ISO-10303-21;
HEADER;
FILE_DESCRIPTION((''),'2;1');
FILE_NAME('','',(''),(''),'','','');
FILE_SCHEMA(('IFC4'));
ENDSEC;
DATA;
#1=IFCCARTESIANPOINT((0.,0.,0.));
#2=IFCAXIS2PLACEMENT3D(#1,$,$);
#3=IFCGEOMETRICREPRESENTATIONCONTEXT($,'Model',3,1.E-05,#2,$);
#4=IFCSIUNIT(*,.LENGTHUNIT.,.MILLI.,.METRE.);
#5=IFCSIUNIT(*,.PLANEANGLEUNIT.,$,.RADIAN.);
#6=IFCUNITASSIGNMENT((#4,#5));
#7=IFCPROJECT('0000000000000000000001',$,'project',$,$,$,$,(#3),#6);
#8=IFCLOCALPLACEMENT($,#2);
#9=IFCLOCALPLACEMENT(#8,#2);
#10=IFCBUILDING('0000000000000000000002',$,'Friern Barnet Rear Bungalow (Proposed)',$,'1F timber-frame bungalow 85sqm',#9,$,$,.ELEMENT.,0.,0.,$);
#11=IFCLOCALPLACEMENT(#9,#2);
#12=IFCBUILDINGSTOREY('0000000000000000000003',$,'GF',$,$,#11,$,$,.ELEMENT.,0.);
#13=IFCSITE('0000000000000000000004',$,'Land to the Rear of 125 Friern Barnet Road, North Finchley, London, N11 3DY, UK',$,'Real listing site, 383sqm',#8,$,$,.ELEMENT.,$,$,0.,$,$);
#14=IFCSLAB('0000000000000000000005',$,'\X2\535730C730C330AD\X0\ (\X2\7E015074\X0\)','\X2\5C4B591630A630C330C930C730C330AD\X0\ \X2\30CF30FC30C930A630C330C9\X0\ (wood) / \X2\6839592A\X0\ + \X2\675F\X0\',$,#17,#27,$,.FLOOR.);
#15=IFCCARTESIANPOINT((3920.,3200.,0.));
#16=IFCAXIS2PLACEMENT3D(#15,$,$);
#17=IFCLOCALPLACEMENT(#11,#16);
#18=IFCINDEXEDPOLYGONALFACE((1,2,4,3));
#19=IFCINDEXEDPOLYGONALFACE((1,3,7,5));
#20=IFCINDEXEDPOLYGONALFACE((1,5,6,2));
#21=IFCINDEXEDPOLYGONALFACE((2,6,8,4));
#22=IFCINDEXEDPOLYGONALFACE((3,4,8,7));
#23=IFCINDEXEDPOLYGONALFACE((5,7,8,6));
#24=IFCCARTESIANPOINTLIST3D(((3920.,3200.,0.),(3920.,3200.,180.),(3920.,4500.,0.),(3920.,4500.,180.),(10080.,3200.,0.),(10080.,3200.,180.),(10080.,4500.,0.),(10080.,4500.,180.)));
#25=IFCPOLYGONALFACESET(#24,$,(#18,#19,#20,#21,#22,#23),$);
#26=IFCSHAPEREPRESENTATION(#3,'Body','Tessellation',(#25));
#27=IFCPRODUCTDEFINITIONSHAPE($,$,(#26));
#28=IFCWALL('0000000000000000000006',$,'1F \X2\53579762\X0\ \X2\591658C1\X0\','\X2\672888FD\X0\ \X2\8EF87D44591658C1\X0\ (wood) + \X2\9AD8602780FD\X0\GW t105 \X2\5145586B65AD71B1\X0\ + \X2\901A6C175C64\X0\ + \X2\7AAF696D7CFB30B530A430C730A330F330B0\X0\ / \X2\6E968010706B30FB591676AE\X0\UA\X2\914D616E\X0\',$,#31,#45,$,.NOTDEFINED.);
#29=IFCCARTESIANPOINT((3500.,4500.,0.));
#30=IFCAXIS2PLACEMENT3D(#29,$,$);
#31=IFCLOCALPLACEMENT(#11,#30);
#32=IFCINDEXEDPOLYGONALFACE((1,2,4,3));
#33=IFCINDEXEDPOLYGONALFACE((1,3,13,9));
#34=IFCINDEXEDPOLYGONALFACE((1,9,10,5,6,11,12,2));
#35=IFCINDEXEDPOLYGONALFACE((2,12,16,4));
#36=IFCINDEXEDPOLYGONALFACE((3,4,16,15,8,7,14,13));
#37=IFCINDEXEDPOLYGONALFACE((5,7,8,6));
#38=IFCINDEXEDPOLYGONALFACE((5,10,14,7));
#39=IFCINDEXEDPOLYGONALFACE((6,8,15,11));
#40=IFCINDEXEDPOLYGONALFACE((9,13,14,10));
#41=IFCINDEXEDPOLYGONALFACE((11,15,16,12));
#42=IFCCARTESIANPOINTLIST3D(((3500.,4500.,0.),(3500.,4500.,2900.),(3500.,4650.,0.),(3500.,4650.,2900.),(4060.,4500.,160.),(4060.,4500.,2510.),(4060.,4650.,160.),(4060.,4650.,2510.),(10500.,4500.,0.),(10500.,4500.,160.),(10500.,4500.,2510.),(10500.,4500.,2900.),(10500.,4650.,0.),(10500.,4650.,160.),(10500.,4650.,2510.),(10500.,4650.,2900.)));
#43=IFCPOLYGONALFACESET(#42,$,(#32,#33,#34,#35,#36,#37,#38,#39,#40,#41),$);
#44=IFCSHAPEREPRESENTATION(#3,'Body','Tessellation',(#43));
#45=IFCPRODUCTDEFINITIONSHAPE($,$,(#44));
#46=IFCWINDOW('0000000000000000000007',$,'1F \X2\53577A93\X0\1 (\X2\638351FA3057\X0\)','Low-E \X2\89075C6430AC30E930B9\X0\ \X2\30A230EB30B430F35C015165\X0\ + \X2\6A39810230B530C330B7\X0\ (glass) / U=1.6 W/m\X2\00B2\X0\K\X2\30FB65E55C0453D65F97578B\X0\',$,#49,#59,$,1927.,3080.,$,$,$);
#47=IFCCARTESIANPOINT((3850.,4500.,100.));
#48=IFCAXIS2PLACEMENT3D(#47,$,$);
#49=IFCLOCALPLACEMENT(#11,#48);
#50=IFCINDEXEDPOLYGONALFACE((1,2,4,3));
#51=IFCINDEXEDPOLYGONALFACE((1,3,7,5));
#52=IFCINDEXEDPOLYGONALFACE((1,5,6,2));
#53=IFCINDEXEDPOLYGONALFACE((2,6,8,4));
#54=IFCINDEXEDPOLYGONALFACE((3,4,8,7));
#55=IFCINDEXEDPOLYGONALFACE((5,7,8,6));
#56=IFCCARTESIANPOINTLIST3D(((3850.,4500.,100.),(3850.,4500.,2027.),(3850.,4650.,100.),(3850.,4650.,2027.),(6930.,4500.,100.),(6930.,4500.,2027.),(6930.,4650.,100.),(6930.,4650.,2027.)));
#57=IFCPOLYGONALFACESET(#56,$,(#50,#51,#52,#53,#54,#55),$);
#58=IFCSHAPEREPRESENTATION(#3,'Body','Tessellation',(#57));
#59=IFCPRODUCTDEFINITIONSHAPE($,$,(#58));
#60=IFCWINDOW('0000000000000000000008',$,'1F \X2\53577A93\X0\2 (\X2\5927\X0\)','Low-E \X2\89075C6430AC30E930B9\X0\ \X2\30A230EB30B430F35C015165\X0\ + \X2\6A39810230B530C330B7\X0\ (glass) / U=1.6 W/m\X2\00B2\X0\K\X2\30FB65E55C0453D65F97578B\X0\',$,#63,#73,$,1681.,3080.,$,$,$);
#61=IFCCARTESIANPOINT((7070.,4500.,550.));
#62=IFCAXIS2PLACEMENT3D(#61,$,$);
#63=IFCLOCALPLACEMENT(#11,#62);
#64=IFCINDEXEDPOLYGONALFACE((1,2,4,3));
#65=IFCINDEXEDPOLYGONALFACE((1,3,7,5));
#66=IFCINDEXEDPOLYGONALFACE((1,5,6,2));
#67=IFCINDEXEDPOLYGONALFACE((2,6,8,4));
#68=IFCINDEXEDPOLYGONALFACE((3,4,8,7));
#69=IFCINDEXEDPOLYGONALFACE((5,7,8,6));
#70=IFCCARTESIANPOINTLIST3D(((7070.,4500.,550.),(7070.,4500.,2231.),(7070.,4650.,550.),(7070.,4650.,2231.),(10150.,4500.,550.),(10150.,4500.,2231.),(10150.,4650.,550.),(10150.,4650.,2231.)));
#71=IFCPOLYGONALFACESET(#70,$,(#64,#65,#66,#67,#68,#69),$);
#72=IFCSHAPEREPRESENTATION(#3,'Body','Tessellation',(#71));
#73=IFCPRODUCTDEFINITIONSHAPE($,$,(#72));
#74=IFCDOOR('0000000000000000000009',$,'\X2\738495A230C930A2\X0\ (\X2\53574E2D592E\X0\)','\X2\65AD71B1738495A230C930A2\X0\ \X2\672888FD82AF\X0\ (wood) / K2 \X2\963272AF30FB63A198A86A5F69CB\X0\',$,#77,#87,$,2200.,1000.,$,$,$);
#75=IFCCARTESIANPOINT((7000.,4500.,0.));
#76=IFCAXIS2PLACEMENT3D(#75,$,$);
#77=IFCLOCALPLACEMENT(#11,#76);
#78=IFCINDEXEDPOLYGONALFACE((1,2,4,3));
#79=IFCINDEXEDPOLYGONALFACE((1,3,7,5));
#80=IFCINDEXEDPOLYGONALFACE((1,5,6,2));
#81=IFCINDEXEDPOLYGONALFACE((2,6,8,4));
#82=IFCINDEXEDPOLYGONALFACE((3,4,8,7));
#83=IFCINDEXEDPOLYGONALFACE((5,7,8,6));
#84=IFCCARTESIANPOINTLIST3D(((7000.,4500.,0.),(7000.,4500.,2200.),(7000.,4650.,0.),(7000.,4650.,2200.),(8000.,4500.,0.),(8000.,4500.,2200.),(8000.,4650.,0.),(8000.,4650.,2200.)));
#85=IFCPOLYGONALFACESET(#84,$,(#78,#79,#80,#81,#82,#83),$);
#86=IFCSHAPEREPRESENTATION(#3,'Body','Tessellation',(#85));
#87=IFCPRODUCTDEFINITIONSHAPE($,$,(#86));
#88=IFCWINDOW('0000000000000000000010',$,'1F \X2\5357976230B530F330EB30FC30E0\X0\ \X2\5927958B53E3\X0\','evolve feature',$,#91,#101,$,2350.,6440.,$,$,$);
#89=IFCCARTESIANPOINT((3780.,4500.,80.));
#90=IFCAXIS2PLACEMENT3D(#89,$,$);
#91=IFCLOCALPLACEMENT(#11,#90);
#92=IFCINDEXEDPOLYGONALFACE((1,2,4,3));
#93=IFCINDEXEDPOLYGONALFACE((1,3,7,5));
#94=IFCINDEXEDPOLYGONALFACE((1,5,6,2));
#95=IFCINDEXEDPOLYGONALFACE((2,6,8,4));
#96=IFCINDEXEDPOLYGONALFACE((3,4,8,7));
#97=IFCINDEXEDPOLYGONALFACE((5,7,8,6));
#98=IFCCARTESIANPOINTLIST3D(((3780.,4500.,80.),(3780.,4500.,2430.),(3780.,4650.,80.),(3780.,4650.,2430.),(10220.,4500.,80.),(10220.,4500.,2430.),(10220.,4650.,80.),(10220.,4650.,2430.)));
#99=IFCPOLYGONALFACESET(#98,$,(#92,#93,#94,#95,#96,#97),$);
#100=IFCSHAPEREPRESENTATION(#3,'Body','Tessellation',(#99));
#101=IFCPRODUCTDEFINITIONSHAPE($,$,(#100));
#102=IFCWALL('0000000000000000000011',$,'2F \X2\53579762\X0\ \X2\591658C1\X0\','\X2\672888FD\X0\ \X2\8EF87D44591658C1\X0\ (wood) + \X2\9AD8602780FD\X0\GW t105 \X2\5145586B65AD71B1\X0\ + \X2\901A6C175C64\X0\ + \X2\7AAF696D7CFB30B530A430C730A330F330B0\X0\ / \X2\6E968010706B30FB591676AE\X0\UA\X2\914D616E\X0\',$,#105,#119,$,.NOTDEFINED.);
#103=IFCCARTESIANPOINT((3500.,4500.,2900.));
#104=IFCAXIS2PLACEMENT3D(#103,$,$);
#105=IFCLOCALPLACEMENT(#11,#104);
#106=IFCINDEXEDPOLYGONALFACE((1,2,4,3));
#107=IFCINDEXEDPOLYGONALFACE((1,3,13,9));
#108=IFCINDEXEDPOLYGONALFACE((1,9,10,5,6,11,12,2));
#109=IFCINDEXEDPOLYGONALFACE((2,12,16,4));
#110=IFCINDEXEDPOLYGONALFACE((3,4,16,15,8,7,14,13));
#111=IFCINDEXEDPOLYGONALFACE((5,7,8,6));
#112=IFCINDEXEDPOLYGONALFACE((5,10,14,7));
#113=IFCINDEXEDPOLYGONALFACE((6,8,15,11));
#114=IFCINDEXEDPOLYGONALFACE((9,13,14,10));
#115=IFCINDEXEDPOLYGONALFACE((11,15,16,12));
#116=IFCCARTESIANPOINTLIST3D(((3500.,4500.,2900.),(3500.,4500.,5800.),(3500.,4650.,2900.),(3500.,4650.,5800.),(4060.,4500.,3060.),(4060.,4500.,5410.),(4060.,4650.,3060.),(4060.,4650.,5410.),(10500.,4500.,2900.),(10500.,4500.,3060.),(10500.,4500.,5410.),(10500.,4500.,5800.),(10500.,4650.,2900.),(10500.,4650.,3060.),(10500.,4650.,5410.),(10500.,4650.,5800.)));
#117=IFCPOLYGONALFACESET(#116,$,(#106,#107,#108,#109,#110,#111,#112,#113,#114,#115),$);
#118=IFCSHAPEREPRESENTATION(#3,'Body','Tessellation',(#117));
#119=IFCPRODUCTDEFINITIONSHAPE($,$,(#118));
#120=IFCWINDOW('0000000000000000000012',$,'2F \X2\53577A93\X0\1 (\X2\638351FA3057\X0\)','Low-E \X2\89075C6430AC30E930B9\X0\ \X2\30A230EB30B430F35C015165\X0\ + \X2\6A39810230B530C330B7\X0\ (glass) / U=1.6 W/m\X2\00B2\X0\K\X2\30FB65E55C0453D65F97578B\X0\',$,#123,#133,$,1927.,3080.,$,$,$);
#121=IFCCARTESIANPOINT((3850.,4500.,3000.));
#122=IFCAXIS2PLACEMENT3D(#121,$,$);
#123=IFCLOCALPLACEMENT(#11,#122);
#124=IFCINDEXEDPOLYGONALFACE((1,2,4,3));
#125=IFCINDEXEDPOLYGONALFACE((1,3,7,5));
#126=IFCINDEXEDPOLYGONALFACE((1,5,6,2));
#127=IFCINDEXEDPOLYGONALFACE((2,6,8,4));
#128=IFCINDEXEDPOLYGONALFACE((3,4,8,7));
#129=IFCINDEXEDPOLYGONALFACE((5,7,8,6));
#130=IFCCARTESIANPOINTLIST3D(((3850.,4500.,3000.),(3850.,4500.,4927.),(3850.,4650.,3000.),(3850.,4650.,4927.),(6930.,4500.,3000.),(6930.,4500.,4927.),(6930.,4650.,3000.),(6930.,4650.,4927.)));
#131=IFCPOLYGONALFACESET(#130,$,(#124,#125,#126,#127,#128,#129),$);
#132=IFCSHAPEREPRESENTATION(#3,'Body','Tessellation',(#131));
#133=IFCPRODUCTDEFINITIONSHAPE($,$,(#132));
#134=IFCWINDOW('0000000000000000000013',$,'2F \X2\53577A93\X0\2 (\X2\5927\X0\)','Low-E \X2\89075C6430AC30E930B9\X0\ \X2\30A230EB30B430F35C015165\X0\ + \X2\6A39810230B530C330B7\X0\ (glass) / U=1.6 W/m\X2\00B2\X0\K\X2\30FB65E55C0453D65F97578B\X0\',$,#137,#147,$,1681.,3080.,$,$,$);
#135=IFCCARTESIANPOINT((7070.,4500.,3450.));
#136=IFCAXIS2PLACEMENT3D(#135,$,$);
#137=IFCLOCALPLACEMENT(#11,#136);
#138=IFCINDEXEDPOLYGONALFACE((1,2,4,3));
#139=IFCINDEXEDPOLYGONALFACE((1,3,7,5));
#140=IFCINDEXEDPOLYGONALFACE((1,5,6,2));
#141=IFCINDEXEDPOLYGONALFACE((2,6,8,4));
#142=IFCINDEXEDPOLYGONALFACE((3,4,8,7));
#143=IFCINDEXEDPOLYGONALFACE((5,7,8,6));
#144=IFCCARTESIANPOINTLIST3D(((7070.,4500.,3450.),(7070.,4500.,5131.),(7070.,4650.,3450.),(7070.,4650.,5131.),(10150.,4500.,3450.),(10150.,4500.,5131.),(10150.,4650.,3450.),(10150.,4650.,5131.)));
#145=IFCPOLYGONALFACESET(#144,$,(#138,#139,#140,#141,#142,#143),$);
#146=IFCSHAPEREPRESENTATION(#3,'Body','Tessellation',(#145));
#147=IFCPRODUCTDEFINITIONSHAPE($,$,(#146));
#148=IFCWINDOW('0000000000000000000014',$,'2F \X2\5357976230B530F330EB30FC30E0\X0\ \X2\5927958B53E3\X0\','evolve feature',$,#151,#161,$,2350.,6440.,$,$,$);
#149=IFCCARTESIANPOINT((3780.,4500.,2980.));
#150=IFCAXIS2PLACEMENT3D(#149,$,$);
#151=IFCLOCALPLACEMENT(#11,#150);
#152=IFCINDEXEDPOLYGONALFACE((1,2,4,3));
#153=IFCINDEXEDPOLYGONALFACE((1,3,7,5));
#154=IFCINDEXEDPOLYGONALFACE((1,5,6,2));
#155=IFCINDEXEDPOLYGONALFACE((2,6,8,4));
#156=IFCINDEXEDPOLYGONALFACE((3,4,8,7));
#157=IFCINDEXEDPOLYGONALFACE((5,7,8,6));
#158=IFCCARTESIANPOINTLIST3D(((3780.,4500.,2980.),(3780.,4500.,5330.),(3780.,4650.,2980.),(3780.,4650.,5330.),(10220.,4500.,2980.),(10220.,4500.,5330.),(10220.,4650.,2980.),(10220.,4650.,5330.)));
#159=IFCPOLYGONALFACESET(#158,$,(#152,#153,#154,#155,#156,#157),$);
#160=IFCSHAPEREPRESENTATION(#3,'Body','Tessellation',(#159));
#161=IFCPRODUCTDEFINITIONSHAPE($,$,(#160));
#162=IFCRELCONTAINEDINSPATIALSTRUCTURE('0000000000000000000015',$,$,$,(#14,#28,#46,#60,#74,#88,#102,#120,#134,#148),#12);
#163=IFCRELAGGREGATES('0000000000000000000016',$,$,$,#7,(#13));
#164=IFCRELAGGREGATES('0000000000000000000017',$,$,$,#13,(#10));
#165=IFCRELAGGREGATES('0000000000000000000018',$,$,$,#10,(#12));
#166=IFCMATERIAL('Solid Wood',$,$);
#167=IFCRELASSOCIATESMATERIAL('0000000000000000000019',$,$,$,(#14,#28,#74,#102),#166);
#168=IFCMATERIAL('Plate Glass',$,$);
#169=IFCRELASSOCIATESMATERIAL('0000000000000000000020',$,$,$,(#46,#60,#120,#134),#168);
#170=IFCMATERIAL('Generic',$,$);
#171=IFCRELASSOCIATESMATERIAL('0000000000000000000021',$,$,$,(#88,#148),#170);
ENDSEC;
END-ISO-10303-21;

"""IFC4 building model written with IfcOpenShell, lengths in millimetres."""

from ifc_helpers import new_model, si_unit, frame, frame_2d, origin, place, context, project, spatial, rectangle, extrude, material, element, fill, save


model = new_model("IFC4")

# Units and contexts
model_context = context("Model", 3, precision=1e-05, world=origin())
ifc_project = project(units=[si_unit("LENGTHUNIT", "METRE", prefix="MILLI"), si_unit("PLANEANGLEUNIT", "RADIAN")], contexts=[model_context])

# Site, building, storey
site_placement = place(None, origin())
site = spatial("IfcSite", under=ifc_project, at=site_placement, Name="Land to the Rear of 125 Friern Barnet Road, North Finchley, London, N11 3DY, UK", ObjectType="Real listing site, 383sqm", CompositionType="ELEMENT", RefElevation=0.0)
building_placement = place(site_placement, origin())
building = spatial("IfcBuilding", under=site, at=building_placement, Name="Friern Barnet Rear Bungalow (Proposed)", ObjectType="1F timber-frame bungalow 85sqm", CompositionType="ELEMENT", ElevationOfRefHeight=0.0, ElevationOfTerrain=0.0)
storey_placement = place(building_placement, origin())
storey = spatial("IfcBuildingStorey", under=building, at=storey_placement, Name="GF", CompositionType="ELEMENT", Elevation=0.0)

# Slab
ifc_material_1 = material(Name="Solid Wood")
slab_1_placement = place(storey_placement, frame((3920.0, 3200.0, 0.0)))
element("IfcSlab", 1, at=slab_1_placement, inside=storey, material=ifc_material_1, Name="南デッキ (縁側)", Description="屋外ウッドデッキ ハードウッド (wood) / 根太 + 束", PredefinedType="FLOOR", context=model_context, shape_type="SweptSolid", body=[
    extrude(rectangle(XDim=6160.0, YDim=1300.0, at=frame_2d((3080.0, 650.0))), frame((3920.0, 3200.0, 0.0)), (0.0, 0.0, 1.0), 180.0),
])
ifc_material_2 = material(Name="Generic")

# Wall, openings, windows, door
wall_1_placement = place(storey_placement, frame((3500.0, 4500.0, 0.0)))
wall_1 = element("IfcWall", 2, at=wall_1_placement, inside=storey, material=ifc_material_1, Name="1F 南面 外壁", Description="木製 軸組外壁 (wood) + 高性能GW t105 充填断熱 + 通気層 + 窯業系サイディング / 準耐火・外皮UA配慮", PredefinedType="NOTDEFINED", context=model_context, shape_type="SweptSolid", body=[
    extrude(rectangle(XDim=7000.0, YDim=150.0, at=frame_2d((3500.0, 75.0))), frame((3500.0, 4500.0, 0.0)), (0.0, 0.0, 1.0), 2900.0),
])
opening_1_placement = place(storey_placement, frame((3850.0, 4500.0, 100.0)))
opening_1 = element("IfcOpeningElement", 3, at=opening_1_placement, cuts=wall_1, PredefinedType="NOTDEFINED", context=model_context, shape_type="SweptSolid", body=[
    extrude(rectangle(XDim=3080.0, YDim=150.0, at=frame_2d((1540.0, 75.0))), frame((3850.0, 4500.0, 100.0)), (0.0, 0.0, 1.0), 1927.0),
])
opening_2_placement = place(storey_placement, frame((7070.0, 4500.0, 550.0)))
opening_2 = element("IfcOpeningElement", 4, at=opening_2_placement, cuts=wall_1, PredefinedType="NOTDEFINED", context=model_context, shape_type="SweptSolid", body=[
    extrude(rectangle(XDim=3080.0, YDim=150.0, at=frame_2d((1540.0, 75.0))), frame((7070.0, 4500.0, 550.0)), (0.0, 0.0, 1.0), 1681.0),
])
opening_3_placement = place(storey_placement, frame((7000.0, 4500.0, 0.0)))
opening_3 = element("IfcOpeningElement", 5, at=opening_3_placement, cuts=wall_1, PredefinedType="NOTDEFINED", context=model_context, shape_type="SweptSolid", body=[
    extrude(rectangle(XDim=1000.0, YDim=150.0, at=frame_2d((500.0, 75.0))), frame((7000.0, 4500.0, 0.0)), (0.0, 0.0, 1.0), 2200.0),
])
opening_4_placement = place(storey_placement, frame((3780.0, 4500.0, 80.0)))
opening_4 = element("IfcOpeningElement", 6, at=opening_4_placement, cuts=wall_1, PredefinedType="NOTDEFINED", context=model_context, shape_type="SweptSolid", body=[
    extrude(rectangle(XDim=6440.0, YDim=150.0, at=frame_2d((3220.0, 75.0))), frame((3780.0, 4500.0, 80.0)), (0.0, 0.0, 1.0), 2350.0),
])
ifc_material_3 = material(Name="Plate Glass")
window_1_placement = place(storey_placement, frame((3850.0, 4500.0, 100.0)))
window_1 = element("IfcWindow", 7, at=window_1_placement, inside=storey, material=ifc_material_3, Name="1F 南窓1 (掃出し)", Description="Low-E 複層ガラス アルゴン封入 + 樹脂サッシ (glass) / U=1.6 W/m²K・日射取得型", OverallHeight=1927.0, OverallWidth=3080.0, context=model_context, shape_type="SweptSolid", body=[
    extrude(rectangle(XDim=3080.0, YDim=150.0, at=frame_2d((1540.0, 75.0))), frame((3850.0, 4500.0, 100.0)), (0.0, 0.0, 1.0), 1927.0),
])
fill(opening_1, window_1)
window_2_placement = place(storey_placement, frame((7070.0, 4500.0, 550.0)))
window_2 = element("IfcWindow", 8, at=window_2_placement, inside=storey, material=ifc_material_3, Name="1F 南窓2 (大)", Description="Low-E 複層ガラス アルゴン封入 + 樹脂サッシ (glass) / U=1.6 W/m²K・日射取得型", OverallHeight=1681.0, OverallWidth=3080.0, context=model_context, shape_type="SweptSolid", body=[
    extrude(rectangle(XDim=3080.0, YDim=150.0, at=frame_2d((1540.0, 75.0))), frame((7070.0, 4500.0, 550.0)), (0.0, 0.0, 1.0), 1681.0),
])
fill(opening_2, window_2)
door_placement = place(storey_placement, frame((7000.0, 4500.0, 0.0)))
door = element("IfcDoor", 9, at=door_placement, inside=storey, material=ifc_material_1, Name="玄関ドア (南中央)", Description="断熱玄関ドア 木製芯 (wood) / K2 防犯・採風機構", OverallHeight=2200.0, OverallWidth=1000.0, context=model_context, shape_type="SweptSolid", body=[
    extrude(rectangle(XDim=1000.0, YDim=150.0, at=frame_2d((500.0, 75.0))), frame((7000.0, 4500.0, 0.0)), (0.0, 0.0, 1.0), 2200.0),
])
fill(opening_3, door)
window_3_placement = place(storey_placement, frame((3780.0, 4500.0, 80.0)))
window_3 = element("IfcWindow", 10, at=window_3_placement, inside=storey, material=ifc_material_2, Name="1F 南面サンルーム 大開口", Description="evolve feature", OverallHeight=2350.0, OverallWidth=6440.0, context=model_context, shape_type="SweptSolid", body=[
    extrude(rectangle(XDim=6440.0, YDim=150.0, at=frame_2d((3220.0, 75.0))), frame((3780.0, 4500.0, 80.0)), (0.0, 0.0, 1.0), 2350.0),
])
fill(opening_4, window_3)

# Wall, openings, windows
wall_2_placement = place(storey_placement, frame((3500.0, 4500.0, 2900.0)))
wall_2 = element("IfcWall", 11, at=wall_2_placement, inside=storey, material=ifc_material_1, Name="2F 南面 外壁", Description="木製 軸組外壁 (wood) + 高性能GW t105 充填断熱 + 通気層 + 窯業系サイディング / 準耐火・外皮UA配慮", PredefinedType="NOTDEFINED", context=model_context, shape_type="SweptSolid", body=[
    extrude(rectangle(XDim=7000.0, YDim=150.0, at=frame_2d((3500.0, 75.0))), frame((3500.0, 4500.0, 2900.0)), (0.0, 0.0, 1.0), 2900.0),
])
opening_5_placement = place(storey_placement, frame((3850.0, 4500.0, 3000.0)))
opening_5 = element("IfcOpeningElement", 12, at=opening_5_placement, cuts=wall_2, PredefinedType="NOTDEFINED", context=model_context, shape_type="SweptSolid", body=[
    extrude(rectangle(XDim=3080.0, YDim=150.0, at=frame_2d((1540.0, 75.0))), frame((3850.0, 4500.0, 3000.0)), (0.0, 0.0, 1.0), 1927.0),
])
opening_6_placement = place(storey_placement, frame((7070.0, 4500.0, 3450.0)))
opening_6 = element("IfcOpeningElement", 13, at=opening_6_placement, cuts=wall_2, PredefinedType="NOTDEFINED", context=model_context, shape_type="SweptSolid", body=[
    extrude(rectangle(XDim=3080.0, YDim=150.0, at=frame_2d((1540.0, 75.0))), frame((7070.0, 4500.0, 3450.0)), (0.0, 0.0, 1.0), 1681.0),
])
opening_7_placement = place(storey_placement, frame((3780.0, 4500.0, 2980.0)))
opening_7 = element("IfcOpeningElement", 14, at=opening_7_placement, cuts=wall_2, PredefinedType="NOTDEFINED", context=model_context, shape_type="SweptSolid", body=[
    extrude(rectangle(XDim=6440.0, YDim=150.0, at=frame_2d((3220.0, 75.0))), frame((3780.0, 4500.0, 2980.0)), (0.0, 0.0, 1.0), 2350.0),
])
window_4_placement = place(storey_placement, frame((3850.0, 4500.0, 3000.0)))
window_4 = element("IfcWindow", 15, at=window_4_placement, inside=storey, material=ifc_material_3, Name="2F 南窓1 (掃出し)", Description="Low-E 複層ガラス アルゴン封入 + 樹脂サッシ (glass) / U=1.6 W/m²K・日射取得型", OverallHeight=1927.0, OverallWidth=3080.0, context=model_context, shape_type="SweptSolid", body=[
    extrude(rectangle(XDim=3080.0, YDim=150.0, at=frame_2d((1540.0, 75.0))), frame((3850.0, 4500.0, 3000.0)), (0.0, 0.0, 1.0), 1927.0),
])
fill(opening_5, window_4)
window_5_placement = place(storey_placement, frame((7070.0, 4500.0, 3450.0)))
window_5 = element("IfcWindow", 16, at=window_5_placement, inside=storey, material=ifc_material_3, Name="2F 南窓2 (大)", Description="Low-E 複層ガラス アルゴン封入 + 樹脂サッシ (glass) / U=1.6 W/m²K・日射取得型", OverallHeight=1681.0, OverallWidth=3080.0, context=model_context, shape_type="SweptSolid", body=[
    extrude(rectangle(XDim=3080.0, YDim=150.0, at=frame_2d((1540.0, 75.0))), frame((7070.0, 4500.0, 3450.0)), (0.0, 0.0, 1.0), 1681.0),
])
fill(opening_6, window_5)
window_6_placement = place(storey_placement, frame((3780.0, 4500.0, 2980.0)))
window_6 = element("IfcWindow", 17, at=window_6_placement, inside=storey, material=ifc_material_2, Name="2F 南面サンルーム 大開口", Description="evolve feature", OverallHeight=2350.0, OverallWidth=6440.0, context=model_context, shape_type="SweptSolid", body=[
    extrude(rectangle(XDim=6440.0, YDim=150.0, at=frame_2d((3220.0, 75.0))), frame((3780.0, 4500.0, 2980.0)), (0.0, 0.0, 1.0), 2350.0),
])
fill(opening_7, window_6)

save(model, "model.ifc")
